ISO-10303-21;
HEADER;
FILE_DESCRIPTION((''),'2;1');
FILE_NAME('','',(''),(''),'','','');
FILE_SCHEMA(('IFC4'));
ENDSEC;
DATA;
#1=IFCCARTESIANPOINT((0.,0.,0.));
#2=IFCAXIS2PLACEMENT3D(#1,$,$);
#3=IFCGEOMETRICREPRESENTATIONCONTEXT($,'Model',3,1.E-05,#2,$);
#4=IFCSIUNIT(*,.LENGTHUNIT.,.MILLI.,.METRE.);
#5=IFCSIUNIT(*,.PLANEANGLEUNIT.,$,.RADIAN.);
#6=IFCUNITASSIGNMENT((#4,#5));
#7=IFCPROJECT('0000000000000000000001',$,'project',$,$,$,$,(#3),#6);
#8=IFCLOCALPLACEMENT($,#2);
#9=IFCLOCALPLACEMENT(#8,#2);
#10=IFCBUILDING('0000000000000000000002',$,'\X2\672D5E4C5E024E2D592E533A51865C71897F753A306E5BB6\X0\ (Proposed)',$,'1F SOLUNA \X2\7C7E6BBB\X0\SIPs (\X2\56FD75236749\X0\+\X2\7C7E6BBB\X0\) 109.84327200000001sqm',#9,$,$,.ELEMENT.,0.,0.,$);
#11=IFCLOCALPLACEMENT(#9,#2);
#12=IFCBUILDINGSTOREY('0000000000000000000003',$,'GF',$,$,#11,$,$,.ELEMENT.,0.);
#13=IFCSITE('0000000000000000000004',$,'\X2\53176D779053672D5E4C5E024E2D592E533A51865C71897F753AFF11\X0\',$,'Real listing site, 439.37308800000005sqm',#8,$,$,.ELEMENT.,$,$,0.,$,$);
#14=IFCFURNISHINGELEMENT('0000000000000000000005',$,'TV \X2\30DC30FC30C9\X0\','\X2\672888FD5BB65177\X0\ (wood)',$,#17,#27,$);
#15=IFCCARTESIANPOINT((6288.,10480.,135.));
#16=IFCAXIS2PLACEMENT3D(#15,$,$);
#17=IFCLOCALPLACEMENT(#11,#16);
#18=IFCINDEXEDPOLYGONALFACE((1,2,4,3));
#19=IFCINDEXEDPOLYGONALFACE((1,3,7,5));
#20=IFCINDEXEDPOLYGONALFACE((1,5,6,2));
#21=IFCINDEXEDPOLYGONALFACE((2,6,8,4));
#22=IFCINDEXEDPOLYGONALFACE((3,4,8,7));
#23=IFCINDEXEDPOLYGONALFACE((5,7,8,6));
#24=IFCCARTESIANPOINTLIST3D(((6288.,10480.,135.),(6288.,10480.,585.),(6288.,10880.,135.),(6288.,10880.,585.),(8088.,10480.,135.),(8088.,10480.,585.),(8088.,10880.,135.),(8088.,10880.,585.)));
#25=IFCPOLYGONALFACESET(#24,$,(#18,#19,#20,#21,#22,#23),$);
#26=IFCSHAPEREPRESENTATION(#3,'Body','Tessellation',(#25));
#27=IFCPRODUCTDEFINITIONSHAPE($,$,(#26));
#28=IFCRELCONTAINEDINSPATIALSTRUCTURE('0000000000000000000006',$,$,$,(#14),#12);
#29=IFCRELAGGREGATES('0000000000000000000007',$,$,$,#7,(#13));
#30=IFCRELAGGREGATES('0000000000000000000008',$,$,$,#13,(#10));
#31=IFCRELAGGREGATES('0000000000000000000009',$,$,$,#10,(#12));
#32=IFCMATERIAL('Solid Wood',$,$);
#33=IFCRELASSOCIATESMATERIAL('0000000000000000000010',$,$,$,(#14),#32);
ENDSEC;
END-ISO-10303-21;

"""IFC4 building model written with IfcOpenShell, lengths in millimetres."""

from ifc_helpers import new_model, si_unit, frame, frame_2d, origin, place, context, project, spatial, rectangle, extrude, material, element, save


model = new_model("IFC4")

# Units and contexts
model_context = context("Model", 3, precision=1e-05, world=origin())
ifc_project = project(units=[si_unit("LENGTHUNIT", "METRE", prefix="MILLI"), si_unit("PLANEANGLEUNIT", "RADIAN")], contexts=[model_context])

# Site, building, storey
site_placement = place(None, origin())
site = spatial("IfcSite", under=ifc_project, at=site_placement, Name="北海道札幌市中央区円山西町１", ObjectType="Real listing site, 439.37308800000005sqm", CompositionType="ELEMENT", RefElevation=0.0)
building_placement = place(site_placement, origin())
building = spatial("IfcBuilding", under=site, at=building_placement, Name="札幌市中央区円山西町の家 (Proposed)", ObjectType="1F SOLUNA 籾殻SIPs (国産杉+籾殻) 109.84327200000001sqm", CompositionType="ELEMENT", ElevationOfRefHeight=0.0, ElevationOfTerrain=0.0)
storey_placement = place(building_placement, origin())
storey = spatial("IfcBuildingStorey", under=building, at=storey_placement, Name="GF", CompositionType="ELEMENT", Elevation=0.0)

# Shared definitions
ifc_material_1 = material(Name="Solid Wood")

# Furnishing element
furnishing_1_placement = place(storey_placement, frame((6288.0, 10480.0, 135.0)))
element("IfcFurnishingElement", 1, at=furnishing_1_placement, inside=storey, material=ifc_material_1, Name="TV ボード", Description="木製家具 (wood)", context=model_context, shape_type="SweptSolid", body=[
    extrude(rectangle(XDim=1800.0, YDim=400.0, at=frame_2d((900.0, 200.0))), frame((6288.0, 10480.0, 135.0)), (0.0, 0.0, 1.0), 450.0),
])

save(model, "model.ifc")
